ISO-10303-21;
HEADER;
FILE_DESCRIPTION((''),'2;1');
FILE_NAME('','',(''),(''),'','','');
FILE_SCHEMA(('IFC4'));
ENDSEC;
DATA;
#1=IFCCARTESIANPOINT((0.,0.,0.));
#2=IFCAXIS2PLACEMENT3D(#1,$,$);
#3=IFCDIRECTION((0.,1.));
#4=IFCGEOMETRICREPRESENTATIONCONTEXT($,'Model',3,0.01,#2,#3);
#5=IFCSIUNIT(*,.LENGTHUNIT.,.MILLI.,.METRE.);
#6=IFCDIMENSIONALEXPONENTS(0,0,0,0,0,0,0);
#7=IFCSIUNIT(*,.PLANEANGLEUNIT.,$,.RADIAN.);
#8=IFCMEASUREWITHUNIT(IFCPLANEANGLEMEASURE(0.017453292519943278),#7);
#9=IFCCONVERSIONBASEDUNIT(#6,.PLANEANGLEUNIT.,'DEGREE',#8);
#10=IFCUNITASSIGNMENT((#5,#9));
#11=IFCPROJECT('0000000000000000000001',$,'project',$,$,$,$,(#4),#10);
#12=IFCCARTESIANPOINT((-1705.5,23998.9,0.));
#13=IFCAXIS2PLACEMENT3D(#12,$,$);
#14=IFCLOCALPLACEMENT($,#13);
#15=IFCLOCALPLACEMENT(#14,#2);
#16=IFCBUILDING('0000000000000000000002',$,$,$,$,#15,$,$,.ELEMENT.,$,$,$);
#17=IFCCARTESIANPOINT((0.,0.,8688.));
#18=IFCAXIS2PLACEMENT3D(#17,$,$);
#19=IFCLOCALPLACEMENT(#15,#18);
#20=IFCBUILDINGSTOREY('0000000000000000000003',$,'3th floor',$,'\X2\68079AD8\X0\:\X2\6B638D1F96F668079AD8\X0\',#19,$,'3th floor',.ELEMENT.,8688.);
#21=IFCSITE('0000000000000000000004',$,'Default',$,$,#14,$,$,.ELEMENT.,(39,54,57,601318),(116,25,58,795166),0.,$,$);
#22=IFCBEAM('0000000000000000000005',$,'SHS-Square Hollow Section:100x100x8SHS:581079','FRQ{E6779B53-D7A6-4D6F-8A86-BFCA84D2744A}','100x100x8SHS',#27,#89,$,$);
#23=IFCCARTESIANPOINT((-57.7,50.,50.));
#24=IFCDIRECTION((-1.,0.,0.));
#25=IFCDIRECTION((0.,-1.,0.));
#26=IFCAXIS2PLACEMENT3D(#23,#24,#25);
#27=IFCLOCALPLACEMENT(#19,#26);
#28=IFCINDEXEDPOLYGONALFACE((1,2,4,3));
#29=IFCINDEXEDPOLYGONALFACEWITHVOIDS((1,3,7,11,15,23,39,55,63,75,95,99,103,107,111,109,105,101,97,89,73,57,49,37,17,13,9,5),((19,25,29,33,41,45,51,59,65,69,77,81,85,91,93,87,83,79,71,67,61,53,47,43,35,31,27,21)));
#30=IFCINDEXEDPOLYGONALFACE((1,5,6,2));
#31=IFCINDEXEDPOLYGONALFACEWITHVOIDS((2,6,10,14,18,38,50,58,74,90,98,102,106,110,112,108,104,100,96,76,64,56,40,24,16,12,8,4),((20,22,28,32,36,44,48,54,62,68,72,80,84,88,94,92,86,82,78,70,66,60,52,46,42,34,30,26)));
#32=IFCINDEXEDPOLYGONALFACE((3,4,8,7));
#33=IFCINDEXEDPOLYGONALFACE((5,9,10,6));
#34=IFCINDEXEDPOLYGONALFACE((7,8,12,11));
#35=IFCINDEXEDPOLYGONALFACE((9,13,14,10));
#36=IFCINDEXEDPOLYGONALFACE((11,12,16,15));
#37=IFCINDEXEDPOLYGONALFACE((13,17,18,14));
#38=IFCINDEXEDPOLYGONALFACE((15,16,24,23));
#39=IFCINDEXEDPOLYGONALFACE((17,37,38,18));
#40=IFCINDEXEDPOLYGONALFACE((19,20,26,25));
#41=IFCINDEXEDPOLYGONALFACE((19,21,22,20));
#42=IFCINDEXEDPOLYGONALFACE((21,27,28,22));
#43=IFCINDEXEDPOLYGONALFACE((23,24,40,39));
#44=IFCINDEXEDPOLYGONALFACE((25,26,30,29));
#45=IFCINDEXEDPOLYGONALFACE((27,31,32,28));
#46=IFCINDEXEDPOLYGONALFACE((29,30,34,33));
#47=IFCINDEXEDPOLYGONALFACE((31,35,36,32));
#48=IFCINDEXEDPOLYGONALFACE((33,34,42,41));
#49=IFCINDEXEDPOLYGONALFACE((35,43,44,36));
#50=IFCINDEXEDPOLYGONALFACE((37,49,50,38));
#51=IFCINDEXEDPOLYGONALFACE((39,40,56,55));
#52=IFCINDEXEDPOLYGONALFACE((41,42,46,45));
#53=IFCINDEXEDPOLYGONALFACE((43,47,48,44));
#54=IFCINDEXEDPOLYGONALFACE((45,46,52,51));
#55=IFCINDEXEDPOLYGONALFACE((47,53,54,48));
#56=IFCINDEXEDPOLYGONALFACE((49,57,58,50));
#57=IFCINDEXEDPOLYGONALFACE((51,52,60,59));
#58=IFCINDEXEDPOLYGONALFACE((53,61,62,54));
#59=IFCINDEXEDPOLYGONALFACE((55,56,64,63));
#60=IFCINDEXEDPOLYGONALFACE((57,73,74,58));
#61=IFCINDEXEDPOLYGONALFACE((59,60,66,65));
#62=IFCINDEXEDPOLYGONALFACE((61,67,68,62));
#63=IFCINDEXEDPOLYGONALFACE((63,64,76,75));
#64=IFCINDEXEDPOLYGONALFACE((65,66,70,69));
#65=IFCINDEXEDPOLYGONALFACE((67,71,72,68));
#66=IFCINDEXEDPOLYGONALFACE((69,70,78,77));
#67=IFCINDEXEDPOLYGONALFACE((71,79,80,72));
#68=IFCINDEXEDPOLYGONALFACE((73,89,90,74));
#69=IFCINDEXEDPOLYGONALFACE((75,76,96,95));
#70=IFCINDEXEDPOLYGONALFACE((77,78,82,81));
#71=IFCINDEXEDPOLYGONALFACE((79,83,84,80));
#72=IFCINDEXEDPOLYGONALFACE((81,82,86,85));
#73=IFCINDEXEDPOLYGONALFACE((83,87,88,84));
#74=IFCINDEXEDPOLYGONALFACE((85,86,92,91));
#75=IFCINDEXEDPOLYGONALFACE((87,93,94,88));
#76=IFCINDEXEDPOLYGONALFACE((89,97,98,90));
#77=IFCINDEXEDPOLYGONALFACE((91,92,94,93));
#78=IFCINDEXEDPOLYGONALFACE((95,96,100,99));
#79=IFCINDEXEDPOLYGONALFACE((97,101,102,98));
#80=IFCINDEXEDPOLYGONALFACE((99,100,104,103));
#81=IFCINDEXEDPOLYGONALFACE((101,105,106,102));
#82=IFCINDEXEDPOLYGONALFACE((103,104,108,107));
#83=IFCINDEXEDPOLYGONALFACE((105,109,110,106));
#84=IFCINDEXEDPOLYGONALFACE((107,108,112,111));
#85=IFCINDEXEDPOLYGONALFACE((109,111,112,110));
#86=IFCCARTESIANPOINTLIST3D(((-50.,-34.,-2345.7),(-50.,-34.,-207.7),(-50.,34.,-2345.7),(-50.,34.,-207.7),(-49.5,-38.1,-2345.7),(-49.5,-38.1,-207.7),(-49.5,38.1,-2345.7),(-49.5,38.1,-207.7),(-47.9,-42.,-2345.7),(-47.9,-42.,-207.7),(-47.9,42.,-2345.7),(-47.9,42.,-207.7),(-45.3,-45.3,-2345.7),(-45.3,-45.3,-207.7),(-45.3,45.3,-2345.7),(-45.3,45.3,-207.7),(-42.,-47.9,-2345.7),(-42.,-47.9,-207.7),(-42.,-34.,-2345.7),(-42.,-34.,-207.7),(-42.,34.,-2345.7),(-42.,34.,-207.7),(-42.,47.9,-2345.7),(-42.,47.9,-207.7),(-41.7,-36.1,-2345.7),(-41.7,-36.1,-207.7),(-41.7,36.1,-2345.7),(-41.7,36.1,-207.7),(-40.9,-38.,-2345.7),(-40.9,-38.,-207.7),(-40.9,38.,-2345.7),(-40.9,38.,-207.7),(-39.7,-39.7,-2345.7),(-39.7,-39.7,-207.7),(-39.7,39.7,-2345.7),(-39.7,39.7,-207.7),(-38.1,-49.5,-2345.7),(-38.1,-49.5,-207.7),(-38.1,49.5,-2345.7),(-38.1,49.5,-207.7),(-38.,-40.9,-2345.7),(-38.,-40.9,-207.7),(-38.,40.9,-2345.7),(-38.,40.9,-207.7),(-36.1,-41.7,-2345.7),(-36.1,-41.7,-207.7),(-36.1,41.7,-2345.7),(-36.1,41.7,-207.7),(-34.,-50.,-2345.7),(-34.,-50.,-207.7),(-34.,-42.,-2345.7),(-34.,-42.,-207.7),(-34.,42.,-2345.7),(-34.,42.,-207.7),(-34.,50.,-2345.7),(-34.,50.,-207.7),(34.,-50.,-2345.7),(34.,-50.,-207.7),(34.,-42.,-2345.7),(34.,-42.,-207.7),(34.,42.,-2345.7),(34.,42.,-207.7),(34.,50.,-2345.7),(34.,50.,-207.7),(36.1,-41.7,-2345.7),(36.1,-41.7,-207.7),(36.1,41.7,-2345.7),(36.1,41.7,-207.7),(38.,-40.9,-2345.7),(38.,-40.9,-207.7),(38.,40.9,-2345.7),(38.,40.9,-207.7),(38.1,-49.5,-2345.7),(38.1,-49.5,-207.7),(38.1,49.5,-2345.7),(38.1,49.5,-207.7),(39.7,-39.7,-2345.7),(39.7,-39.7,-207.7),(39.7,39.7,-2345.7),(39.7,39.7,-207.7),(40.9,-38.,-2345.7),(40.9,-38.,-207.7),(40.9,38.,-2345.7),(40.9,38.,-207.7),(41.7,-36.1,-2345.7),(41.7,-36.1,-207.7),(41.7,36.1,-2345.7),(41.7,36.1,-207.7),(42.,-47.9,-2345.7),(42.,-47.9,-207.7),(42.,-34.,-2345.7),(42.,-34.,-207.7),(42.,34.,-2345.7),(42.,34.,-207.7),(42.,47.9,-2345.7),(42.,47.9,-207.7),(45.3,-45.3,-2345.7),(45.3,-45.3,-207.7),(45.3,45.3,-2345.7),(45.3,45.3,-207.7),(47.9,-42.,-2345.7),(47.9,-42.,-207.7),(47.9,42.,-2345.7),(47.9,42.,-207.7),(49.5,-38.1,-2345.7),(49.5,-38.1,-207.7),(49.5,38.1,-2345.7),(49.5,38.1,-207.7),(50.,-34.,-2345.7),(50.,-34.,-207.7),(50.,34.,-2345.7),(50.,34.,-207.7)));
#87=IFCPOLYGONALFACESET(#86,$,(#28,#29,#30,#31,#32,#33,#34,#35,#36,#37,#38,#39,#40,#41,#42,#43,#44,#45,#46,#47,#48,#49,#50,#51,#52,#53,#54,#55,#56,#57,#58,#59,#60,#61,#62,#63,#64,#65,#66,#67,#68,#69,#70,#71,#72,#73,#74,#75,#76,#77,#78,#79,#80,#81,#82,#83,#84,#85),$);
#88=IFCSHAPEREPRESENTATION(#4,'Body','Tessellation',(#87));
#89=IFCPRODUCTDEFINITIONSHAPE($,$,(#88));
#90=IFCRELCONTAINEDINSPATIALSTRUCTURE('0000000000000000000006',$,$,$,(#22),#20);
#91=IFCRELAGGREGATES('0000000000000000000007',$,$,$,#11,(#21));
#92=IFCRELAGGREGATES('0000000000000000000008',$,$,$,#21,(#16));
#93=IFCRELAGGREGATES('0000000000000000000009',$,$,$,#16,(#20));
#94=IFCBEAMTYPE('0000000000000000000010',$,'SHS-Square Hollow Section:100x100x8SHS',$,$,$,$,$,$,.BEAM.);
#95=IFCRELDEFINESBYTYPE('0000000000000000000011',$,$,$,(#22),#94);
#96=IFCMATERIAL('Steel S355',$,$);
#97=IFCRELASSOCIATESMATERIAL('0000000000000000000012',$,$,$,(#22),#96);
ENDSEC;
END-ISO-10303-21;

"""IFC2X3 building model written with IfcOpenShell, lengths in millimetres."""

from ifc_helpers import new_model, entity, si_unit, converted_unit, direction, frame, origin, origin_2d, place, context, project, spatial, hollow_rectangle, extrude, clip, halfspace, material, type_object, element, save


model = new_model("IFC2X3")

# Units and contexts
model_context = context("Model", 3, precision=0.01, world=origin(), true_north=direction((0.0, 1.0)))
ifc_project = project(units=[si_unit("LENGTHUNIT", "METRE", prefix="MILLI"), converted_unit("PLANEANGLEUNIT", "DEGREE", entity("IfcPlaneAngleMeasure", 0.017453292519943278), si_unit("PLANEANGLEUNIT", "RADIAN"), dimensions=[0, 0, 0, 0, 0, 0, 0])], contexts=[model_context])

# Site, building, storey
site_placement = place(None, frame((-1705.5, 23998.9, 0.0)))
site = spatial("IfcSite", under=ifc_project, at=site_placement, Name="Default", CompositionType="ELEMENT", RefLatitude=(39, 54, 57, 601318), RefLongitude=(116, 25, 58, 795166), RefElevation=0.0)
building_placement = place(site_placement, origin())
building = spatial("IfcBuilding", under=site, at=building_placement, CompositionType="ELEMENT")
storey_placement = place(building_placement, frame((0.0, 0.0, 8688.0)))
storey = spatial("IfcBuildingStorey", under=building, at=storey_placement, Name="3th floor", ObjectType="标高:正负零标高", LongName="3th floor", CompositionType="ELEMENT", Elevation=8688.0)

# Shared definitions
ifc_material_1 = material(Name="Steel S355")

# Beam
beam_type = type_object("IfcBeamType", Name="SHS-Square Hollow Section:100x100x8SHS", PredefinedType="BEAM")
beam_placement = place(storey_placement, frame((-57.7, 50.0, 50.0), z_axis=(-1.0, 0.0, 0.0), x_axis=(0.0, -1.0, 0.0)))
element("IfcBeam", 1, at=beam_placement, inside=storey, type_object=beam_type, material=ifc_material_1, Name="SHS-Square Hollow Section:100x100x8SHS:581079", Description="FRQ{E6779B53-D7A6-4D6F-8A86-BFCA84D2744A}", ObjectType="100x100x8SHS", context=model_context, shape_type="Clipping", body=[
    clip(clip(extrude(hollow_rectangle(XDim=100.0, YDim=100.0, WallThickness=8.0, InnerFilletRadius=8.0, OuterFilletRadius=16.0, at=origin_2d()), origin(), (0.0, 0.0, -1.0), 2551.4), halfspace(frame((50.0, -8738.0, -2345.7), z_axis=(0.0, 0.0, 1.0), x_axis=(1.0, 0.0, 0.0)), True)), halfspace(frame((50.0, -8738.0, -207.7), z_axis=(0.0, 0.0, -1.0), x_axis=(-1.0, 0.0, 0.0)), True)),
])

save(model, "model.ifc")
